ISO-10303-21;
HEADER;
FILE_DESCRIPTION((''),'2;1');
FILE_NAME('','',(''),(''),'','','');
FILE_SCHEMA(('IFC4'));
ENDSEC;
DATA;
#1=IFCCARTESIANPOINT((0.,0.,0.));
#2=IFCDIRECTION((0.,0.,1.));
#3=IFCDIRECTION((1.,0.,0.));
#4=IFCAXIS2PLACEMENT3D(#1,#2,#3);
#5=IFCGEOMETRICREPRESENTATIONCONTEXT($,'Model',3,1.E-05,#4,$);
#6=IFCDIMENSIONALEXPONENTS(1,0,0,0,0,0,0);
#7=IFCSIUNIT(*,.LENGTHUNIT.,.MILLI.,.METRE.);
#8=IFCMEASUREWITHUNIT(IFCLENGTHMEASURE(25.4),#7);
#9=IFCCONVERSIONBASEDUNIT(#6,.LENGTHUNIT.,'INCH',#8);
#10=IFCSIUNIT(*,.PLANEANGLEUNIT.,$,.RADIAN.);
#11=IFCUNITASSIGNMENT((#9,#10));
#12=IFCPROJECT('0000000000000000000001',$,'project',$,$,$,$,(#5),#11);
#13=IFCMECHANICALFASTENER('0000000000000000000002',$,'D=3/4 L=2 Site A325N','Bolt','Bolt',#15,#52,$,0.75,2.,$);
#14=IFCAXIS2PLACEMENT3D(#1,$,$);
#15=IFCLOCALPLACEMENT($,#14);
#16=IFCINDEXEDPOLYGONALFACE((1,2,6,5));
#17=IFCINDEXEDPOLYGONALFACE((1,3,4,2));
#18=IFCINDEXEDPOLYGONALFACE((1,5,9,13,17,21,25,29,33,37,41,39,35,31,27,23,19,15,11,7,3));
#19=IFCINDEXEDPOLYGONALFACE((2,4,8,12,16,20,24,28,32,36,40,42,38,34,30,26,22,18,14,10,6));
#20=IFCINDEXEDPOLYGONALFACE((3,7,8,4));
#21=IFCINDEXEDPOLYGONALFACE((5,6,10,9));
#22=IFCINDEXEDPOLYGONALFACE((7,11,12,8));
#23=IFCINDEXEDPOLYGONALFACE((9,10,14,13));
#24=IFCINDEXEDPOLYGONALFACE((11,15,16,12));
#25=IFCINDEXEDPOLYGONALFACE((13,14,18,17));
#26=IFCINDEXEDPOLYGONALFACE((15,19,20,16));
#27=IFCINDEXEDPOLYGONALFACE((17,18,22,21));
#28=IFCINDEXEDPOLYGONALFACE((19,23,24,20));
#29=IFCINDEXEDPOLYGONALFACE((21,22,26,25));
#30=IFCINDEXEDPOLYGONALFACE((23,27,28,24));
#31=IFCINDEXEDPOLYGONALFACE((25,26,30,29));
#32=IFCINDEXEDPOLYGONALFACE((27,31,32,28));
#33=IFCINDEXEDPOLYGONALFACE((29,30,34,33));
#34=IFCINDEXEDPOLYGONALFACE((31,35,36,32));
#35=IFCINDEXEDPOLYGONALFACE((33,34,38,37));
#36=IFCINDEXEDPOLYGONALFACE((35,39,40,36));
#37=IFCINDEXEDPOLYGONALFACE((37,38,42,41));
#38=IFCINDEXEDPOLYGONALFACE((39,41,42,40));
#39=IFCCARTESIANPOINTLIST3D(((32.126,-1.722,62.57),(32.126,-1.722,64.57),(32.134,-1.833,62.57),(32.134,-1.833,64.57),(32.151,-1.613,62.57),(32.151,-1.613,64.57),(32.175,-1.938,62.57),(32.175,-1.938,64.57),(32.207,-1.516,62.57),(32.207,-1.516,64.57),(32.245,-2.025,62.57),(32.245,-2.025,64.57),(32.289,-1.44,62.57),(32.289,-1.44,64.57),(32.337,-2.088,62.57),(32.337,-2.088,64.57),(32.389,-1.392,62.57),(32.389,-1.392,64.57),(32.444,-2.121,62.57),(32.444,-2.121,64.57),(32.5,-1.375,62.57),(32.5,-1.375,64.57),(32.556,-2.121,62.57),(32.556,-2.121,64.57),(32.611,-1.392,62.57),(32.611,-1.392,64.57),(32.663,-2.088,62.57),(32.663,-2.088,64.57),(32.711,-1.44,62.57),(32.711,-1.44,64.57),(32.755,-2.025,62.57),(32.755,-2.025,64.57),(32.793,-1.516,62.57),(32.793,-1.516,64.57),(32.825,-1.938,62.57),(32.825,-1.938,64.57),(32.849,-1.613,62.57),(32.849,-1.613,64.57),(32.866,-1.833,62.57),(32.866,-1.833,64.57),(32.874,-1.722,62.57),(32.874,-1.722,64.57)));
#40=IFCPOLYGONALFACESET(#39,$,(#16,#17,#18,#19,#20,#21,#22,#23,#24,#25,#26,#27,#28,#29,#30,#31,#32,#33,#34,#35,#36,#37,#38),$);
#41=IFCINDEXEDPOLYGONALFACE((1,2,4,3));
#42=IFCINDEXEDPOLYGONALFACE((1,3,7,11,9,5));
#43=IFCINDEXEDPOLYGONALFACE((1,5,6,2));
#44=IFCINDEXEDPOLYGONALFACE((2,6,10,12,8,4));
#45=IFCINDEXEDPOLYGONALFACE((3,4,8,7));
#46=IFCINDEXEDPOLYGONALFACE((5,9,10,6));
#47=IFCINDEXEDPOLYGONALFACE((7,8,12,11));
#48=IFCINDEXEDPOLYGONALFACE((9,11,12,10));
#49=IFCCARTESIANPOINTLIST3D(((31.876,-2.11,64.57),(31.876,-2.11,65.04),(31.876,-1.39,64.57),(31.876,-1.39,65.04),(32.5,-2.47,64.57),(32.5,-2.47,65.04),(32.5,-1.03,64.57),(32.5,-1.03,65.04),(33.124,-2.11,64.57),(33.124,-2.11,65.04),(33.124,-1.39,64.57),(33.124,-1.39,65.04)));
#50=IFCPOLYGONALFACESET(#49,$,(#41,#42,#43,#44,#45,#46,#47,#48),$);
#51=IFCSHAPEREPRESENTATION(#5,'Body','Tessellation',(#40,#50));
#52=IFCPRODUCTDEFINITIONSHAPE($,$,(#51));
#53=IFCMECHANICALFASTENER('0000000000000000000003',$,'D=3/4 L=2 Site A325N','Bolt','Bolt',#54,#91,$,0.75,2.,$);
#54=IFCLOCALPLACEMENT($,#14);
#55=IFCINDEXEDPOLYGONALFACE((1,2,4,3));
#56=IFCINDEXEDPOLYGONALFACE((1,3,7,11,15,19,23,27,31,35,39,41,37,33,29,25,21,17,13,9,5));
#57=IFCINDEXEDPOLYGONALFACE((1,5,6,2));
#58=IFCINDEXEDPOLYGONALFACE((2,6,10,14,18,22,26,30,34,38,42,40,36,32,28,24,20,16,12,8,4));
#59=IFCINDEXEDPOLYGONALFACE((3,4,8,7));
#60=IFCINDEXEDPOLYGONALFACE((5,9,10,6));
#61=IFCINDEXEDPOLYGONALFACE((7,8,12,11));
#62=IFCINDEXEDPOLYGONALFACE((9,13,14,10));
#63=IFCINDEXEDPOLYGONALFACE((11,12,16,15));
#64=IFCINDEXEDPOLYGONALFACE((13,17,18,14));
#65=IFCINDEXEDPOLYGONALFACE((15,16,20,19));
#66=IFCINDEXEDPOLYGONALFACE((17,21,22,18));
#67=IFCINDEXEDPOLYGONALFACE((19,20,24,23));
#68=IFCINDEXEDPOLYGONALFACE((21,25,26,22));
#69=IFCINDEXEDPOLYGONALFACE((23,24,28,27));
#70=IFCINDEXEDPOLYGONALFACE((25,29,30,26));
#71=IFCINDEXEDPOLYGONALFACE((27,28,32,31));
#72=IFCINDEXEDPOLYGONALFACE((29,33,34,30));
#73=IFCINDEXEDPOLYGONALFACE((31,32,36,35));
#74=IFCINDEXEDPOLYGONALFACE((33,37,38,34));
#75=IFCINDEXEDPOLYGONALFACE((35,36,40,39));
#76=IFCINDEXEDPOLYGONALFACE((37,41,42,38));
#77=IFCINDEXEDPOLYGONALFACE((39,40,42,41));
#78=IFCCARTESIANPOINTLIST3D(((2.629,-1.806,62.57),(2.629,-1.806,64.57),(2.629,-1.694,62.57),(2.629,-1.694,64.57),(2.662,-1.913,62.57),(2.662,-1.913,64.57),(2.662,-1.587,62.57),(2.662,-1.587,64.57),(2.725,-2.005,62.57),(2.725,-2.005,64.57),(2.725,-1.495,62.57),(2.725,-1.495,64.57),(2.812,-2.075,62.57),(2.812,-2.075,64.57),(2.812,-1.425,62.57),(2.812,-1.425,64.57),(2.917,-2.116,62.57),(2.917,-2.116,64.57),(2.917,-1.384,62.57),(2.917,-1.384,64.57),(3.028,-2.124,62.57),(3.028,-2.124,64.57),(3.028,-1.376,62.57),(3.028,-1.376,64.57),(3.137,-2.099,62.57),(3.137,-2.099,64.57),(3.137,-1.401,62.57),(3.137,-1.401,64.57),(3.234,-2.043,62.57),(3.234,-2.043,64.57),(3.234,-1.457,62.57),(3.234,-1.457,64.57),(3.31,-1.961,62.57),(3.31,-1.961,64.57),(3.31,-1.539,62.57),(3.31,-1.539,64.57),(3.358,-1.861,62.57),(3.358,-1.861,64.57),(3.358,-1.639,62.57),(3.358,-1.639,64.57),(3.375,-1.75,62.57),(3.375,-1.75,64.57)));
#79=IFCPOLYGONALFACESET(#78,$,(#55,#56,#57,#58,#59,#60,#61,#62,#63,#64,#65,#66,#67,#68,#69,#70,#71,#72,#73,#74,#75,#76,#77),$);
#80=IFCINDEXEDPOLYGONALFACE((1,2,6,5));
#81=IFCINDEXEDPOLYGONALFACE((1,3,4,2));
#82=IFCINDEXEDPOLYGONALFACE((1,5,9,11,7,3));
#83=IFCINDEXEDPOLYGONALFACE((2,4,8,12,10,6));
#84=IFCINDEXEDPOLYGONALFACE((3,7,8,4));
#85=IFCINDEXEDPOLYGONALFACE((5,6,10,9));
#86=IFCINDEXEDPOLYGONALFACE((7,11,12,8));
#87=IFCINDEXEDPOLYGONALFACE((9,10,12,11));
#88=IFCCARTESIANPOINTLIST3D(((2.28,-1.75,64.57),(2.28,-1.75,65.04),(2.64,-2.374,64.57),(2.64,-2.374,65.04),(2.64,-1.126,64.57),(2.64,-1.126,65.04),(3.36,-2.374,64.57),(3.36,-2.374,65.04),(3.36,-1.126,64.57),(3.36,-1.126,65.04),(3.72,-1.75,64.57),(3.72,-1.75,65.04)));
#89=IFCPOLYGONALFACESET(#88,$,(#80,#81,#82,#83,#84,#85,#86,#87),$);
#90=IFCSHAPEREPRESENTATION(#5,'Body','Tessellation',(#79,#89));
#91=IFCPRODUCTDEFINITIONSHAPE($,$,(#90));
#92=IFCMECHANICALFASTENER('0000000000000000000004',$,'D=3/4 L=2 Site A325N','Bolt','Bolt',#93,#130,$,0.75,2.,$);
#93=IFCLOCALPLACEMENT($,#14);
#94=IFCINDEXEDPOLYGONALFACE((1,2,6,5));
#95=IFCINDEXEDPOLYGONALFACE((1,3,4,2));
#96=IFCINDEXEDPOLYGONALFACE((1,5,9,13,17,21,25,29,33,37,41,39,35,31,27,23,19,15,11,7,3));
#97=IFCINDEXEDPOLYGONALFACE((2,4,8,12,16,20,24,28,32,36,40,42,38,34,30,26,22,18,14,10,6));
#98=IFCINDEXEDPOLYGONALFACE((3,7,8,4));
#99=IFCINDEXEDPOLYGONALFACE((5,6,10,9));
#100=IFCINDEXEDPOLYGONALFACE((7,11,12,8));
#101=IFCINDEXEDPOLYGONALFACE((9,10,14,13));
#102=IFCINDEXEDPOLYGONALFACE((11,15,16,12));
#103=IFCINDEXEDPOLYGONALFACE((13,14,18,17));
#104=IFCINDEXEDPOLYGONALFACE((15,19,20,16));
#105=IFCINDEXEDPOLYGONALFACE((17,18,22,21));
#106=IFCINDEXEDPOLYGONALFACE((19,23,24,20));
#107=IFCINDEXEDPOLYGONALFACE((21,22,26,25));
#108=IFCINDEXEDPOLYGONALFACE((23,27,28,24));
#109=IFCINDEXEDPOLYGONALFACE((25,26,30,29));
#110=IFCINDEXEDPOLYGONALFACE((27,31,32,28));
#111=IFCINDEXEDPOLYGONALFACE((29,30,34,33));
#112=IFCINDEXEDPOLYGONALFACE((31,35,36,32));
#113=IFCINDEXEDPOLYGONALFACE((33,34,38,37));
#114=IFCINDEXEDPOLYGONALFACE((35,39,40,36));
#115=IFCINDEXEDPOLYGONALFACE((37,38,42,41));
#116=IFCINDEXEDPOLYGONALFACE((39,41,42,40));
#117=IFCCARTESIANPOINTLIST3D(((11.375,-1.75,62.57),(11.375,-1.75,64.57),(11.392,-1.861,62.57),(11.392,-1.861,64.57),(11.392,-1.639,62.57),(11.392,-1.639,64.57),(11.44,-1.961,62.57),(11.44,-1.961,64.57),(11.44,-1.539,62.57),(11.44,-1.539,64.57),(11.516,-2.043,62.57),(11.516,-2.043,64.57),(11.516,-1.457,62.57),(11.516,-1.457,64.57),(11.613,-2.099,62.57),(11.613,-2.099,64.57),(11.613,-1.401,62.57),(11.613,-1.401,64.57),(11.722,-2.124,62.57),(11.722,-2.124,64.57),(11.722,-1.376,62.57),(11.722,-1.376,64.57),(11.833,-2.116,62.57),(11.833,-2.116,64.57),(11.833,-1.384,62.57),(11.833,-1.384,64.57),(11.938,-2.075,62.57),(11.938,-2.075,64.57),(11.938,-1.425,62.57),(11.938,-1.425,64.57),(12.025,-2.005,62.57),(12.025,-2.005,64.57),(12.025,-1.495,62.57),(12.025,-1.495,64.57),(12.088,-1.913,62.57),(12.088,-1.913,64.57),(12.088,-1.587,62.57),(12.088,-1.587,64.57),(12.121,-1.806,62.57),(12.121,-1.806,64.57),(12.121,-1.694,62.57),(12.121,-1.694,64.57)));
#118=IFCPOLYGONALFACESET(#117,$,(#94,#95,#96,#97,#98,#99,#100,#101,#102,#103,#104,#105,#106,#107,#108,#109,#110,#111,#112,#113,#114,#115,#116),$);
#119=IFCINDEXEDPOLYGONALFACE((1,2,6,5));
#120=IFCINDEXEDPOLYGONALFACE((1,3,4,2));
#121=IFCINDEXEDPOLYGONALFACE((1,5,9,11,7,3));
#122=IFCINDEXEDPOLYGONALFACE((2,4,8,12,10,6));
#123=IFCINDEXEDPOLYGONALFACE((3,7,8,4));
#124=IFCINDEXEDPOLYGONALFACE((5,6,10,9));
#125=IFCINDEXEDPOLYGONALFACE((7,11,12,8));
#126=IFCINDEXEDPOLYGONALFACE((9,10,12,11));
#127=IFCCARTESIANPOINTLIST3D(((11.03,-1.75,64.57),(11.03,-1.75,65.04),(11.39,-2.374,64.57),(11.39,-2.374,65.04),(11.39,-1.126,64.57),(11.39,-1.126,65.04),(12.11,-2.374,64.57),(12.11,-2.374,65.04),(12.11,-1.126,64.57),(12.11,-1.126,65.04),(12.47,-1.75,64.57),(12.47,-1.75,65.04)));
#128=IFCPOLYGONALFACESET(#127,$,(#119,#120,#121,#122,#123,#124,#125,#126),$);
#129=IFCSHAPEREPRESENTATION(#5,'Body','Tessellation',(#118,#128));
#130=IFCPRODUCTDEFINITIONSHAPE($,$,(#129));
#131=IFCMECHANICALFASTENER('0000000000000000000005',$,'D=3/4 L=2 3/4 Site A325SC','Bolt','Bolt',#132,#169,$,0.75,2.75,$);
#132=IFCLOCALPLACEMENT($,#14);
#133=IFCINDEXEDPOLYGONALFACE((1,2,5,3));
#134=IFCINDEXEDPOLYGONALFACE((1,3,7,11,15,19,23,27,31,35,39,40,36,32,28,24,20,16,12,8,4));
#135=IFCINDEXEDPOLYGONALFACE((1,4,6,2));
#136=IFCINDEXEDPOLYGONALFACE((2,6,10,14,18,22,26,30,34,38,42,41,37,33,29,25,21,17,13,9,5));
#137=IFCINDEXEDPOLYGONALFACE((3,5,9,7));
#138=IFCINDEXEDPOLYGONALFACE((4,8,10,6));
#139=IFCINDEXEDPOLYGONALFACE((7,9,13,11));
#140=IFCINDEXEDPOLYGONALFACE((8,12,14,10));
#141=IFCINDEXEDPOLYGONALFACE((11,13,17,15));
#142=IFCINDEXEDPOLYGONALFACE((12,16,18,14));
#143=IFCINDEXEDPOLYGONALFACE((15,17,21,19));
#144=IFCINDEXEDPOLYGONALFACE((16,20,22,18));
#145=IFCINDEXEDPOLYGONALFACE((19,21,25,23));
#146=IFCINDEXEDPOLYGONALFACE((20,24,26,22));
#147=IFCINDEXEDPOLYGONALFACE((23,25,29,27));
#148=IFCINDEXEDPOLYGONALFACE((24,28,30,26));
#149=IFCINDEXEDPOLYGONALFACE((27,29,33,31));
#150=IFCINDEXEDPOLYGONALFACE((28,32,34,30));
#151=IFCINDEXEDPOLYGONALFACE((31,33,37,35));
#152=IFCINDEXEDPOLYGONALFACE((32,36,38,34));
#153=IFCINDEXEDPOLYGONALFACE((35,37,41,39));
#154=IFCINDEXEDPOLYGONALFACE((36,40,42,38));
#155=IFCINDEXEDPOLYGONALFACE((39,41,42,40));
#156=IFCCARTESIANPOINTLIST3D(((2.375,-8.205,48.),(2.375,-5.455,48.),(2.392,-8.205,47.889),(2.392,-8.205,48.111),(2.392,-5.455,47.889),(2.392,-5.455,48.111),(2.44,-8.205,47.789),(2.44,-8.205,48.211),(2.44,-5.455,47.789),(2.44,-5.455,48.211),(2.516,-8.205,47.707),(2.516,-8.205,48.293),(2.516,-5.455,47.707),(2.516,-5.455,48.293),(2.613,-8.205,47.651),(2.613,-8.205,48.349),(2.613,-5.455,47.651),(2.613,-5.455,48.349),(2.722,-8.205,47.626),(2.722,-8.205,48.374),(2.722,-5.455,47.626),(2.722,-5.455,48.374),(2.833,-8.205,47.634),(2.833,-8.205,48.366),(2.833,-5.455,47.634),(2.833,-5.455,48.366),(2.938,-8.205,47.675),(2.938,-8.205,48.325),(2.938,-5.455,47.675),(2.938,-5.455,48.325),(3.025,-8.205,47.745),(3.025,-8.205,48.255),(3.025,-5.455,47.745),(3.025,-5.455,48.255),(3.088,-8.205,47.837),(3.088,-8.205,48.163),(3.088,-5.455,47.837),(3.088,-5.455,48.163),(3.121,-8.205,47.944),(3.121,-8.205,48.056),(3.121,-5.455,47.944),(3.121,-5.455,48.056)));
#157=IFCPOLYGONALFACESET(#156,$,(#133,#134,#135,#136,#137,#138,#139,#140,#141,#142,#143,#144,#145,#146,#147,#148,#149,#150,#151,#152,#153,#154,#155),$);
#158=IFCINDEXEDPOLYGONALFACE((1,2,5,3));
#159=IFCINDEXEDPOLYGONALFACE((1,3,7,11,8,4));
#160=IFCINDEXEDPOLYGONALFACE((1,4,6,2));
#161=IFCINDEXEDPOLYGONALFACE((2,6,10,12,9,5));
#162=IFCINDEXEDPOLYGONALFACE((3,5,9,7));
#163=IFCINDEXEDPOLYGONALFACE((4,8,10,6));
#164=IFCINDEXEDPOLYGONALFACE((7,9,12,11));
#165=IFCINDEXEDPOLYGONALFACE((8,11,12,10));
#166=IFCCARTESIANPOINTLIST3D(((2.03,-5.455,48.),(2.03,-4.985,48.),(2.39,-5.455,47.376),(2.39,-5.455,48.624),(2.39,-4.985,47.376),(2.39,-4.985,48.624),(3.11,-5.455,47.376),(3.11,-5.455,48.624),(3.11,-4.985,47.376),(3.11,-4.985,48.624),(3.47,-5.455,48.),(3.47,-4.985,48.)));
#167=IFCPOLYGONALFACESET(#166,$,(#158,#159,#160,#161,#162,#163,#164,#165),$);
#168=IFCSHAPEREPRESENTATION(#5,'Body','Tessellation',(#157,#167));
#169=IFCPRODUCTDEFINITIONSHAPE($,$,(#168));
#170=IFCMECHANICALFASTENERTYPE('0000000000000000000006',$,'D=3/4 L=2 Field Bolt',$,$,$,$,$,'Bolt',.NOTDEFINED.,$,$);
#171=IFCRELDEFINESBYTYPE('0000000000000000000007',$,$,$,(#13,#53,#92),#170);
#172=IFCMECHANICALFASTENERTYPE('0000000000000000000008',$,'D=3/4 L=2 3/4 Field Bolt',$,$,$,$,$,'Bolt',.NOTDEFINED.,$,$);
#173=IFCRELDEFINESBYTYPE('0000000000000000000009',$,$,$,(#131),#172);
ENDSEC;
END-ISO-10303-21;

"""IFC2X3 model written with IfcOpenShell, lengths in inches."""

from ifc_helpers import new_model, entity, si_unit, converted_unit, frame, origin_with_axes, origin_2d_with_axis, place, context, project, polyline, circle, outline, extrude, source, transform, mapped, type_object, type_shapes, element, save


model = new_model("IFC2X3")

# Units and contexts
model_context = context("Model", 3, precision=1e-05, world=origin_with_axes())
ifc_project = project(units=[converted_unit("LENGTHUNIT", "INCH", entity("IfcLengthMeasure", 25.4), si_unit("LENGTHUNIT", "METRE", prefix="MILLI"), dimensions=[1, 0, 0, 0, 0, 0, 0]), si_unit("PLANEANGLEUNIT", "RADIAN")], contexts=[model_context])

# Mechanical fasteners
placement_1 = place(None, origin_with_axes())
placement_2 = place(placement_1, origin_with_axes())
mechanical_fastener_type_1 = type_object("IfcMechanicalFastenerType", Name="D=3/4 L=2 Field Bolt", ElementType="Bolt")
shared_shape_1 = source(origin_with_axes(), model_context, "Body", "SweptSolid", [
    extrude(circle(Radius=0.375, at=origin_2d_with_axis()), frame((0.0, 0.0, 0.0), z_axis=(1.0, 0.0, 0.0), x_axis=(0.0, 1.0, 0.0)), (0.0, 0.0, 1.0), 2.0),
    extrude(outline(polyline([(-0.72, 0.0), (-0.36, 0.624), (0.36, 0.624), (0.72, 0.0), (0.36, -0.624), (-0.36, -0.624), (-0.72, 0.0)])), frame((0.0, 0.0, 0.0), z_axis=(1.0, 0.0, 0.0), x_axis=(0.0, 1.0, 0.0)), (0.0, 0.0, -1.0), 0.47),
])
type_shapes(mechanical_fastener_type_1, [shared_shape_1])
placement_3 = place(placement_2, frame((36.0, 0.0, 46.0), z_axis=(-1.0, 0.0, 0.0), x_axis=(0.0, 0.0, 1.0)))
placement_4 = place(placement_3, frame((18.57, -1.75, 3.5), z_axis=(0.0, 0.0, -1.0), x_axis=(-1.0, 0.0, 0.0)))
for number, where, z_axis, x_axis, name in (
    (1, (0.0, 0.0, 0.0), (0.0, 0.0, 1.0), (1.0, 0.0, 0.0), "D=3/4 L=2 Site A325N"),
):
    element("IfcMechanicalFastener", number, at=place(placement_4, frame(where, z_axis=z_axis, x_axis=x_axis)), type_object=mechanical_fastener_type_1, Name=name, Description="Bolt", ObjectType="Bolt", NominalDiameter=0.75, NominalLength=2.0, context=model_context, shape_type="MappedRepresentation", body=[
        mapped(shared_shape_1, transform((0.0, 0.0, 0.0), scale=1.0)),
    ])
placement_5 = place(placement_2, frame((0.0, 0.0, 80.0), z_axis=(0.0, 0.0, 1.0), x_axis=(1.0, 0.0, 0.0)))
placement_6 = place(placement_5, frame((3.0, 1.75, -15.43), z_axis=(0.0, -1.0, 0.0), x_axis=(0.0, 0.0, -1.0)))
mechanical_fastener_1_placement = place(placement_6, frame((0.0, 0.0, 3.5), z_axis=(0.0, 0.0, 1.0), x_axis=(1.0, 0.0, 0.0)))
element("IfcMechanicalFastener", 2, at=mechanical_fastener_1_placement, type_object=mechanical_fastener_type_1, Name="D=3/4 L=2 Site A325N", Description="Bolt", ObjectType="Bolt", NominalDiameter=0.75, NominalLength=2.0, context=model_context, shape_type="MappedRepresentation", body=[
    mapped(shared_shape_1, transform((0.0, 0.0, 0.0), scale=1.0)),
])
placement_7 = place(placement_2, frame((14.0, 0.0, 49.0), z_axis=(0.0, -1.0, 0.0), x_axis=(0.0, 0.0, 1.0)))
placement_8 = place(placement_7, frame((15.57, 2.25, -1.75), z_axis=(0.0, 0.0, -1.0), x_axis=(-1.0, 0.0, 0.0)))
mechanical_fastener_2_placement = place(placement_8, frame((0.0, 0.0, -3.5), z_axis=(0.0, 0.0, 1.0), x_axis=(1.0, 0.0, 0.0)))
element("IfcMechanicalFastener", 3, at=mechanical_fastener_2_placement, type_object=mechanical_fastener_type_1, Name="D=3/4 L=2 Site A325N", Description="Bolt", ObjectType="Bolt", NominalDiameter=0.75, NominalLength=2.0, context=model_context, shape_type="MappedRepresentation", body=[
    mapped(shared_shape_1, transform((0.0, 0.0, 0.0), scale=1.0)),
])
mechanical_fastener_type_2 = type_object("IfcMechanicalFastenerType", Name="D=3/4 L=2 3/4 Field Bolt", ElementType="Bolt")
shared_shape_2 = source(origin_with_axes(), model_context, "Body", "SweptSolid", [
    extrude(circle(Radius=0.375, at=origin_2d_with_axis()), frame((0.0, 0.0, 0.0), z_axis=(1.0, 0.0, 0.0), x_axis=(0.0, 1.0, 0.0)), (0.0, 0.0, 1.0), 2.75),
    extrude(outline(polyline([(-0.72, 0.0), (-0.36, 0.624), (0.36, 0.624), (0.72, 0.0), (0.36, -0.624), (-0.36, -0.624), (-0.72, 0.0)])), frame((0.0, 0.0, 0.0), z_axis=(1.0, 0.0, 0.0), x_axis=(0.0, 1.0, 0.0)), (0.0, 0.0, -1.0), 0.47),
])
type_shapes(mechanical_fastener_type_2, [shared_shape_2])
placement_9 = place(placement_2, frame((0.0, 0.0, 46.0), z_axis=(0.0, 0.0, 1.0), x_axis=(0.0, -1.0, 0.0)))
placement_10 = place(placement_9, frame((5.455, -2.75, 2.0), z_axis=(0.0, 0.0, -1.0), x_axis=(1.0, 0.0, 0.0)))
mechanical_fastener_3_placement = place(placement_10, frame((0.0, -5.5, 0.0), z_axis=(0.0, 0.0, 1.0), x_axis=(1.0, 0.0, 0.0)))
element("IfcMechanicalFastener", 4, at=mechanical_fastener_3_placement, type_object=mechanical_fastener_type_2, Name="D=3/4 L=2 3/4 Site A325SC", Description="Bolt", ObjectType="Bolt", NominalDiameter=0.75, NominalLength=2.75, context=model_context, shape_type="MappedRepresentation", body=[
    mapped(shared_shape_2, transform((0.0, 0.0, 0.0), scale=1.0)),
])

save(model, "model.ifc")
